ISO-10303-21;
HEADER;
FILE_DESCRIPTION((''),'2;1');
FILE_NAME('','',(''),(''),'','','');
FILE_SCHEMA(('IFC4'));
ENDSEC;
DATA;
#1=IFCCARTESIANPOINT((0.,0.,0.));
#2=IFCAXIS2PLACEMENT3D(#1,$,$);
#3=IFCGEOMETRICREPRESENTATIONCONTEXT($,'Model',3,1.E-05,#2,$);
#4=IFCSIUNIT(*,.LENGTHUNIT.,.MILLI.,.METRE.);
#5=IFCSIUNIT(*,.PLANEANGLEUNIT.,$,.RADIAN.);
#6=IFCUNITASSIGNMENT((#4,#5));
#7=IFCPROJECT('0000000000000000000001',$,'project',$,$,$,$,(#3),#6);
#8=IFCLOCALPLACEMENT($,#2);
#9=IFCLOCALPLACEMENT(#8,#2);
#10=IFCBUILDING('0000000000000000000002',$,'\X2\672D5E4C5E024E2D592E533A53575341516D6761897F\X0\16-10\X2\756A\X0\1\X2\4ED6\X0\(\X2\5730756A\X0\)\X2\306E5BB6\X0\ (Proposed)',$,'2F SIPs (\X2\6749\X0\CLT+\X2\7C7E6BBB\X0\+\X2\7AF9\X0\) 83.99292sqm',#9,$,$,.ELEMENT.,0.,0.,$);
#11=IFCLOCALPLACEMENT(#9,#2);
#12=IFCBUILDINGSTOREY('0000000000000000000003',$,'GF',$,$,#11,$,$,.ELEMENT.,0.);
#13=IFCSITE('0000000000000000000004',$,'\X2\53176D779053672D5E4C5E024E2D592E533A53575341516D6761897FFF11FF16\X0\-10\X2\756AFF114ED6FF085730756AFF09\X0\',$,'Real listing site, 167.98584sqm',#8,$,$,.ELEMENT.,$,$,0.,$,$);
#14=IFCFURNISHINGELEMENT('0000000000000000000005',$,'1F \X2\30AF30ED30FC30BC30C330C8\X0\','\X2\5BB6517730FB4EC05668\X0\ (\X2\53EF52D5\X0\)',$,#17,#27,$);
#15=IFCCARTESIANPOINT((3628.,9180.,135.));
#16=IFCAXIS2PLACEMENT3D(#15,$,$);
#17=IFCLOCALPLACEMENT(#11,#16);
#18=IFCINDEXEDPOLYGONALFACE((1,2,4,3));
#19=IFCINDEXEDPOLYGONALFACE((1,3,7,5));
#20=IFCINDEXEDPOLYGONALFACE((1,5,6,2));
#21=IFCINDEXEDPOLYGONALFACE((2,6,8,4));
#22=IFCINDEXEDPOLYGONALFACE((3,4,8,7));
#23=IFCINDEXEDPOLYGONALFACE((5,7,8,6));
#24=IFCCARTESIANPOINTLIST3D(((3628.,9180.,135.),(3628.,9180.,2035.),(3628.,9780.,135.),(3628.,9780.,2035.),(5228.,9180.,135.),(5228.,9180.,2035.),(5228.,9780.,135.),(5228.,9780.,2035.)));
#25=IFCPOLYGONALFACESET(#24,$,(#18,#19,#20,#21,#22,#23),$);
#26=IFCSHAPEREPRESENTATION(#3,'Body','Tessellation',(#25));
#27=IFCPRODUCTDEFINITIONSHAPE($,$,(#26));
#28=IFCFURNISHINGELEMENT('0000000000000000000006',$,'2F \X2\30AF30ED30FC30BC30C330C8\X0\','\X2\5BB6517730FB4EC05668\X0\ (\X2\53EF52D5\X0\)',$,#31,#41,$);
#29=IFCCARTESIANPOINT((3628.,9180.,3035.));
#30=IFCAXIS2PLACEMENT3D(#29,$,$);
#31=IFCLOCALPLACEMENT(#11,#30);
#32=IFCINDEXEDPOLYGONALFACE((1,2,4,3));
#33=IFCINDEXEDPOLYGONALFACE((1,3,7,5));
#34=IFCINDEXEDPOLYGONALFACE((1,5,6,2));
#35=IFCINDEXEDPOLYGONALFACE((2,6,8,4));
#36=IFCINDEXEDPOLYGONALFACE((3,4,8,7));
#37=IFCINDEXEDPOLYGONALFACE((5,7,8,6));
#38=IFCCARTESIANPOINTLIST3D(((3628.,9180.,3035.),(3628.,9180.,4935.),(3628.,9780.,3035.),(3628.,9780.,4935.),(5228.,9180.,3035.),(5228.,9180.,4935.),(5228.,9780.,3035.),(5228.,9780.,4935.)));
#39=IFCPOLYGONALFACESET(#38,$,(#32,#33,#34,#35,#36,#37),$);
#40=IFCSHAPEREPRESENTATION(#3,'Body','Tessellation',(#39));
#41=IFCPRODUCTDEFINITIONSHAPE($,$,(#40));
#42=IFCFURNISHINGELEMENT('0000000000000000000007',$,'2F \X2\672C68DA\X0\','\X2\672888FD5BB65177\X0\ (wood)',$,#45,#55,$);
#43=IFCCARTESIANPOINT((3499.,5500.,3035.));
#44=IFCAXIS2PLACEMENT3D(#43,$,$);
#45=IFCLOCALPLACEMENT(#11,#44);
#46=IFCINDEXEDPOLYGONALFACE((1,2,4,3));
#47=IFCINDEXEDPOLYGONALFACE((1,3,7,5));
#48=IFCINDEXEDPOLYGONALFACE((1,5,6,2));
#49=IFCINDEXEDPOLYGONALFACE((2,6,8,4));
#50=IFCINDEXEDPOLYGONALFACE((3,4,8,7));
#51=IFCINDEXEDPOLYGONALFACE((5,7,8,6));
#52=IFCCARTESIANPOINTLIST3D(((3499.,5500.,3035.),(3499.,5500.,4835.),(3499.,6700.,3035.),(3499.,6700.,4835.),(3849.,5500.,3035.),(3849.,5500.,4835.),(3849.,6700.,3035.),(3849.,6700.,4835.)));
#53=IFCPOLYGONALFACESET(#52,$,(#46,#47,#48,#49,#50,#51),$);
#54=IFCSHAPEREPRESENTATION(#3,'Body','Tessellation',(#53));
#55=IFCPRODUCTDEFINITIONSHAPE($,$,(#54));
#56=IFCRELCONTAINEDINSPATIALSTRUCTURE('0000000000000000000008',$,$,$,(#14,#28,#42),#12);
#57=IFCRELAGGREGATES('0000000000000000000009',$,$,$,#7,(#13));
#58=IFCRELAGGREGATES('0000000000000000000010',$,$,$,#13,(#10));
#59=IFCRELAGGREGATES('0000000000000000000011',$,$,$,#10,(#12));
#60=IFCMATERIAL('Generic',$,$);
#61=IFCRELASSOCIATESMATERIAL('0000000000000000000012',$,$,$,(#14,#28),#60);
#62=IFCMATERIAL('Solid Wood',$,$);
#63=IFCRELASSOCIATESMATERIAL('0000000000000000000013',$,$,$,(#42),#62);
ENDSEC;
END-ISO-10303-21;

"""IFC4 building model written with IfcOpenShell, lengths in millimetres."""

from ifc_helpers import new_model, si_unit, frame, frame_2d, origin, place, context, project, spatial, rectangle, extrude, material, element, save


model = new_model("IFC4")

# Units and contexts
model_context = context("Model", 3, precision=1e-05, world=origin())
ifc_project = project(units=[si_unit("LENGTHUNIT", "METRE", prefix="MILLI"), si_unit("PLANEANGLEUNIT", "RADIAN")], contexts=[model_context])

# Site, building, storey
site_placement = place(None, origin())
site = spatial("IfcSite", under=ifc_project, at=site_placement, Name="北海道札幌市中央区南十六条西１６-10番１他（地番）", ObjectType="Real listing site, 167.98584sqm", CompositionType="ELEMENT", RefElevation=0.0)
building_placement = place(site_placement, origin())
building = spatial("IfcBuilding", under=site, at=building_placement, Name="札幌市中央区南十六条西16-10番1他(地番)の家 (Proposed)", ObjectType="2F SIPs (杉CLT+籾殻+竹) 83.99292sqm", CompositionType="ELEMENT", ElevationOfRefHeight=0.0, ElevationOfTerrain=0.0)
storey_placement = place(building_placement, origin())
storey = spatial("IfcBuildingStorey", under=building, at=storey_placement, Name="GF", CompositionType="ELEMENT", Elevation=0.0)

# Shared definitions
ifc_material_1 = material(Name="Solid Wood")

# Shared definitions
ifc_material_2 = material(Name="Generic")

# Furnishing elements
furnishing_1_placement = place(storey_placement, frame((3628.0, 9180.0, 135.0)))
element("IfcFurnishingElement", 1, at=furnishing_1_placement, inside=storey, material=ifc_material_2, Name="1F クローゼット", Description="家具・什器 (可動)", context=model_context, shape_type="SweptSolid", body=[
    extrude(rectangle(XDim=1600.0, YDim=600.0, at=frame_2d((800.0, 300.0))), frame((3628.0, 9180.0, 135.0)), (0.0, 0.0, 1.0), 1900.0),
])
furnishing_2_placement = place(storey_placement, frame((3628.0, 9180.0, 3035.0)))
element("IfcFurnishingElement", 2, at=furnishing_2_placement, inside=storey, material=ifc_material_2, Name="2F クローゼット", Description="家具・什器 (可動)", context=model_context, shape_type="SweptSolid", body=[
    extrude(rectangle(XDim=1600.0, YDim=600.0, at=frame_2d((800.0, 300.0))), frame((3628.0, 9180.0, 3035.0)), (0.0, 0.0, 1.0), 1900.0),
])
furnishing_3_placement = place(storey_placement, frame((3499.0, 5500.0, 3035.0)))
element("IfcFurnishingElement", 3, at=furnishing_3_placement, inside=storey, material=ifc_material_1, Name="2F 本棚", Description="木製家具 (wood)", context=model_context, shape_type="SweptSolid", body=[
    extrude(rectangle(XDim=350.0, YDim=1200.0, at=frame_2d((175.0, 600.0))), frame((3499.0, 5500.0, 3035.0)), (0.0, 0.0, 1.0), 1800.0),
])

save(model, "model.ifc")
